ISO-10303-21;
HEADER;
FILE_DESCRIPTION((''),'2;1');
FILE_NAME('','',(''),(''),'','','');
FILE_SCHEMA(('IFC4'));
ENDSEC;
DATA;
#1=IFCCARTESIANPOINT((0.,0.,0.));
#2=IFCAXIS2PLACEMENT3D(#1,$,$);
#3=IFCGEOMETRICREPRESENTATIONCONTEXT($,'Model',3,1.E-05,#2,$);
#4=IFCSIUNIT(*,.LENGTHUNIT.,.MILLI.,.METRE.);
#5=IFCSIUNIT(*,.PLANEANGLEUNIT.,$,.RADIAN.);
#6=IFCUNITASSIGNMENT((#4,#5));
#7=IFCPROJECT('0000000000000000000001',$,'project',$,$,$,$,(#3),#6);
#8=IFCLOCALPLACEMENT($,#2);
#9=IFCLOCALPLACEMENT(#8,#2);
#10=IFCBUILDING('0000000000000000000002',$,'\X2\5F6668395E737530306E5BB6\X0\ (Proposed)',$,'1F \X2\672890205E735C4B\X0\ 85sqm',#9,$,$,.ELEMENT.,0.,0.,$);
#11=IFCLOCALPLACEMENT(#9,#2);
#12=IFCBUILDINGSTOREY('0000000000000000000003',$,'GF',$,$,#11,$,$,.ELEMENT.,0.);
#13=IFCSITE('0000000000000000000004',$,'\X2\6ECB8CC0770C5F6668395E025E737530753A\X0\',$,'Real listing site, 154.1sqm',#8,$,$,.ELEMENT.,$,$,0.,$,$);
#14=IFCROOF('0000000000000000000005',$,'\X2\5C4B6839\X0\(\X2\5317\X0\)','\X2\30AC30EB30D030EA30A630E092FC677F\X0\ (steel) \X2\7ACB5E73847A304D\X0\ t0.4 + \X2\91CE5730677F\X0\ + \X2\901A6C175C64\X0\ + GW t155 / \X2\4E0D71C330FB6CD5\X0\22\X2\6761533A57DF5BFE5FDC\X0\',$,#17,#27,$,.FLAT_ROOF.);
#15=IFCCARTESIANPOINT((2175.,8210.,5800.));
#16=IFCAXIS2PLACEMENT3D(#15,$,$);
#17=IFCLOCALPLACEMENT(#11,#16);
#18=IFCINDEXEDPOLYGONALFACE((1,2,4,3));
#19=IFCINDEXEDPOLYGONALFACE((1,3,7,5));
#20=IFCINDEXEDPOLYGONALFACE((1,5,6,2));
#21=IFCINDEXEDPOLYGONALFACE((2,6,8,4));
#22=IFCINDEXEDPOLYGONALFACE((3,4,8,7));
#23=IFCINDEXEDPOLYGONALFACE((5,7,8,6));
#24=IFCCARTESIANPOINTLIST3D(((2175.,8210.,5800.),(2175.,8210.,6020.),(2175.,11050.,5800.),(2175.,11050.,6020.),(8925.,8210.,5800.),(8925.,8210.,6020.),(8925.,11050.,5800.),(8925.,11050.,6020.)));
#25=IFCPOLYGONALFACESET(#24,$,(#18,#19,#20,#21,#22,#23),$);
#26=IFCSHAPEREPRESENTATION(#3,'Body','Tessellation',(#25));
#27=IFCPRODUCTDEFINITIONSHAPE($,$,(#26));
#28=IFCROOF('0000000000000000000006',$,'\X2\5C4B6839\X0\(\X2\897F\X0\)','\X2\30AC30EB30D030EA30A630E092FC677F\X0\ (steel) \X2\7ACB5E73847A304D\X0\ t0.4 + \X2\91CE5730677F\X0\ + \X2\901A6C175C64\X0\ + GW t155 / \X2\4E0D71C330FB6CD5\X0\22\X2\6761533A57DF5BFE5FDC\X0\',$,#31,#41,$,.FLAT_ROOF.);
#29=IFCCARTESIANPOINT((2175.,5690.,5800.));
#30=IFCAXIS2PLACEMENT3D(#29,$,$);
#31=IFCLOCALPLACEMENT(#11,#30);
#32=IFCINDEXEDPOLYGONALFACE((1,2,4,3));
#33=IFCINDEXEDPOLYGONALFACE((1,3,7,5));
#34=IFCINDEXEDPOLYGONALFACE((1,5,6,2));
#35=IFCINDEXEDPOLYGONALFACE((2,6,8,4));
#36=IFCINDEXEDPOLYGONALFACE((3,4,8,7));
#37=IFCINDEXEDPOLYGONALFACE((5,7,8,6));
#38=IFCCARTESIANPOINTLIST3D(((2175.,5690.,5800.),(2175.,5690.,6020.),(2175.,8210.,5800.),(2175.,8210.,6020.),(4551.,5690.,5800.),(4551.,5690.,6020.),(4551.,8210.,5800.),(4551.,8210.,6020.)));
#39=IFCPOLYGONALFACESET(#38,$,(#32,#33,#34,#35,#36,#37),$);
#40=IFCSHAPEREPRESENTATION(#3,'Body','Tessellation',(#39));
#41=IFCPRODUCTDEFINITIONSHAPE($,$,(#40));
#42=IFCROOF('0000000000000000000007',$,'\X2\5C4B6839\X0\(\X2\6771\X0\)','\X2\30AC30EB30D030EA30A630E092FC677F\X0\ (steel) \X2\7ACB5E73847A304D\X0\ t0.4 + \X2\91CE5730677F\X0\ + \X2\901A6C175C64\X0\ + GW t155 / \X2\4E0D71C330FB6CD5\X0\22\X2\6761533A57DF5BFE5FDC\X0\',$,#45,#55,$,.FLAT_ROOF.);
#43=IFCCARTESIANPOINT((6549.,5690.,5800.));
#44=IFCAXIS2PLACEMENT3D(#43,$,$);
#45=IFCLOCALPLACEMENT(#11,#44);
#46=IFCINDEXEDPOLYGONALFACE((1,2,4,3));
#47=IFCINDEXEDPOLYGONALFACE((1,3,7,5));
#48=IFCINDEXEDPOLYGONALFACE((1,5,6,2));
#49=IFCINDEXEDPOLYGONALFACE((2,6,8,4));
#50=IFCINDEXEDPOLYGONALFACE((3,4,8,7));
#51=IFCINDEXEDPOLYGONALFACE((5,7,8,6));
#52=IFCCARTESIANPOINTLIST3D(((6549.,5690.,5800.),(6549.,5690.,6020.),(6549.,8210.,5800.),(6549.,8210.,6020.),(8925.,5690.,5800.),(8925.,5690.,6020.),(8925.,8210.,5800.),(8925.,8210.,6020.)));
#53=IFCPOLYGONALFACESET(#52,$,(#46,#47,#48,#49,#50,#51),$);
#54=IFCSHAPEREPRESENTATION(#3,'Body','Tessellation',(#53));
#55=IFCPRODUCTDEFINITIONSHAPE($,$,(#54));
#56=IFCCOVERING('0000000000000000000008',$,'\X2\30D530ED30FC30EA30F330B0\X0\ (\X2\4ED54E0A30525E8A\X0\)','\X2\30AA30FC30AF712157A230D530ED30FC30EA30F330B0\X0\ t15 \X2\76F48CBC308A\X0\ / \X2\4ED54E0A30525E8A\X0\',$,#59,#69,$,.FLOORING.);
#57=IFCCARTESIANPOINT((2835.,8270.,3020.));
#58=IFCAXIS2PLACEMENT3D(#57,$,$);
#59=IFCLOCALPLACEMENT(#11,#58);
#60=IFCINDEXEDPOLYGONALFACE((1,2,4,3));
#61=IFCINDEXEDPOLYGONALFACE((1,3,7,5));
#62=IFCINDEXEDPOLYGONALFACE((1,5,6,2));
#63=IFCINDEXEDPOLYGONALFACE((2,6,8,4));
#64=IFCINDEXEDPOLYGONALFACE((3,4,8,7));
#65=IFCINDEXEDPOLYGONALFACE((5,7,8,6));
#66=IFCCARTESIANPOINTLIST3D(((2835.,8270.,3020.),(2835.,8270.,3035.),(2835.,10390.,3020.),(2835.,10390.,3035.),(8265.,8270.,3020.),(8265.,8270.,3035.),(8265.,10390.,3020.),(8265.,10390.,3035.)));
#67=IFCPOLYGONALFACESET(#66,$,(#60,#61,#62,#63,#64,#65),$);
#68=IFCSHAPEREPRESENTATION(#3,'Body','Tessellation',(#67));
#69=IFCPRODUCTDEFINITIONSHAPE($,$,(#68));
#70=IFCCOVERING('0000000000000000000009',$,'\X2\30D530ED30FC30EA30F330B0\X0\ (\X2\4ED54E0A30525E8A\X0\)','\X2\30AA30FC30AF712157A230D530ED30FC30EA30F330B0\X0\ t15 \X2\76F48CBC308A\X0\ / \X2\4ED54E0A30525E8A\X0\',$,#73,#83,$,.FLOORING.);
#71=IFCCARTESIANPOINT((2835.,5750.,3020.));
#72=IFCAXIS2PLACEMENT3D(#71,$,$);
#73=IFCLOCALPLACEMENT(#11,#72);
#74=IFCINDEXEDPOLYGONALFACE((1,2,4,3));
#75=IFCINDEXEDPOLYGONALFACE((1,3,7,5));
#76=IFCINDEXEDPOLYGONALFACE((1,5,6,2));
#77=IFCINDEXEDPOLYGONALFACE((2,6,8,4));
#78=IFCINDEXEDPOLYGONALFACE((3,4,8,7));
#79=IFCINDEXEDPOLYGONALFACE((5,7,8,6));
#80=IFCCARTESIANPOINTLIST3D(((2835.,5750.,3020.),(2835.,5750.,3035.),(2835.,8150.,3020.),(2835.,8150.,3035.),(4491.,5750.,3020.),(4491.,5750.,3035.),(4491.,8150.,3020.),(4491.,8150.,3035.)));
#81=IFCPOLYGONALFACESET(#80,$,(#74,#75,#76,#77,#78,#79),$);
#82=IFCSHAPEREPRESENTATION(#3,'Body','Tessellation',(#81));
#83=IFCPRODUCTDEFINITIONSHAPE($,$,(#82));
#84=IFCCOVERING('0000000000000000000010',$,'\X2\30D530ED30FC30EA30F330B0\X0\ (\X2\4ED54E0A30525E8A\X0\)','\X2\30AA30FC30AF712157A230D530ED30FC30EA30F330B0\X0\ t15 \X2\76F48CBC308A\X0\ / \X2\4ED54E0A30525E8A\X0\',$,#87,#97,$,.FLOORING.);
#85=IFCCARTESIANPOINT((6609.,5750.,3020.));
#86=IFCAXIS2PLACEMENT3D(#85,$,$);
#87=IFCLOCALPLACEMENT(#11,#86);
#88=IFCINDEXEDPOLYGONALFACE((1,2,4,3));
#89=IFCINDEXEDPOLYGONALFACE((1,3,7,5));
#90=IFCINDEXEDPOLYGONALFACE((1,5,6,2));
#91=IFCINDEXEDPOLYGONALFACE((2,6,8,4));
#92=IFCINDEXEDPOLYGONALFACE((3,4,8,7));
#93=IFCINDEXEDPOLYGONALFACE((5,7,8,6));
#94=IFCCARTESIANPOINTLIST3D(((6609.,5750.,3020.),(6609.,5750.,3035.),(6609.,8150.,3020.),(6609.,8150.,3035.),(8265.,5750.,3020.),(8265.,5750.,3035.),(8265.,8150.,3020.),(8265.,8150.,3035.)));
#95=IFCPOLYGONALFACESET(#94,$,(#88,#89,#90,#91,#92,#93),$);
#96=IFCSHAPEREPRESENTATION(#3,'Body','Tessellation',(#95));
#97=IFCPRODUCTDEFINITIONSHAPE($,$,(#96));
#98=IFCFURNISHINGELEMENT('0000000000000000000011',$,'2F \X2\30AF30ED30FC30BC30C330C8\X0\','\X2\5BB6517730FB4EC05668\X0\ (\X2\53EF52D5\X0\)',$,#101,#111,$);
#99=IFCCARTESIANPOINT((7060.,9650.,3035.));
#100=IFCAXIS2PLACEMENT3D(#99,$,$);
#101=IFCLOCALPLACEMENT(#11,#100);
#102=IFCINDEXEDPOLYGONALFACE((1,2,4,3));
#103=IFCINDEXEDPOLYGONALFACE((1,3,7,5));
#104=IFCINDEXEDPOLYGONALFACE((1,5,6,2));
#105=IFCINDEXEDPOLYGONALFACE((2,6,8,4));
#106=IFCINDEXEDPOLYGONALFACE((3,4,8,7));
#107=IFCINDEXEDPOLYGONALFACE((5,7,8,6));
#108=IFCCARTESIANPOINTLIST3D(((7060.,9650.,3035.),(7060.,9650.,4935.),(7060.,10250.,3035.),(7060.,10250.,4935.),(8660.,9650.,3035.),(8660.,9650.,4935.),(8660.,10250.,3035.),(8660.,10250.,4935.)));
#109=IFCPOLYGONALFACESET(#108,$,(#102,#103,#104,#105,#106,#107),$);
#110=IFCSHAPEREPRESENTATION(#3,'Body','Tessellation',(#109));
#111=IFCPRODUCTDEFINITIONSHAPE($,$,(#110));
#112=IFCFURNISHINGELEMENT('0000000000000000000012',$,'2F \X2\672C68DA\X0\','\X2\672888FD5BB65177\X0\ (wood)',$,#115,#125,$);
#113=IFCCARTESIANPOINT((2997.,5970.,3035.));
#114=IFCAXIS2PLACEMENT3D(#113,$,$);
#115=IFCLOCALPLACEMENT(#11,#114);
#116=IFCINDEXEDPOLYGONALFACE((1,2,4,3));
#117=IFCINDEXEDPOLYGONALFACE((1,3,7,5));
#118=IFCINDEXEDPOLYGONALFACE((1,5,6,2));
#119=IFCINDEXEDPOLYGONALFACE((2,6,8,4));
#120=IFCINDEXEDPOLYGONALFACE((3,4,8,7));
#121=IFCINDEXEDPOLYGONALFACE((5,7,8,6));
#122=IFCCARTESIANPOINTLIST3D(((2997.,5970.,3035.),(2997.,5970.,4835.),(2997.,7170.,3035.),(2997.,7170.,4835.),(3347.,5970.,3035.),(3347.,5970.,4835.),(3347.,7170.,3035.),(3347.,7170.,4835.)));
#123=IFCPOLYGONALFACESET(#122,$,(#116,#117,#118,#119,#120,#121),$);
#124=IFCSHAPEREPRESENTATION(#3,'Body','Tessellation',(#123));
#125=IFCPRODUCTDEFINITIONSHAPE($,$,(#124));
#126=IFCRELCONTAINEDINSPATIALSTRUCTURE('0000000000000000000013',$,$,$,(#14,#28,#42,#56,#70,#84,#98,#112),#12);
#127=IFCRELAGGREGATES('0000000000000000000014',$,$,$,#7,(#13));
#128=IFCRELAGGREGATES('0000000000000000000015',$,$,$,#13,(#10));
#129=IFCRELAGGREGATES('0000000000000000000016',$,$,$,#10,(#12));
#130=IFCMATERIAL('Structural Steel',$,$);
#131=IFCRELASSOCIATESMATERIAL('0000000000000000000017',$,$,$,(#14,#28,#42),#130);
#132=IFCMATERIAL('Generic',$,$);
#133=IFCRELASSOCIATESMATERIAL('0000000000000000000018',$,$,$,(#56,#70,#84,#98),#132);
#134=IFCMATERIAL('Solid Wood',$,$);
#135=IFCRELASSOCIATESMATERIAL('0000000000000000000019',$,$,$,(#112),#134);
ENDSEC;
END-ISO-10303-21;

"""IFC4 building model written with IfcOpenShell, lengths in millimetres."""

from ifc_helpers import new_model, si_unit, frame, frame_2d, origin, place, context, project, spatial, rectangle, extrude, material, element, save


model = new_model("IFC4")

# Units and contexts
model_context = context("Model", 3, precision=1e-05, world=origin())
ifc_project = project(units=[si_unit("LENGTHUNIT", "METRE", prefix="MILLI"), si_unit("PLANEANGLEUNIT", "RADIAN")], contexts=[model_context])

# Site, building, storey
site_placement = place(None, origin())
site = spatial("IfcSite", under=ifc_project, at=site_placement, Name="滋賀県彦根市平田町", ObjectType="Real listing site, 154.1sqm", CompositionType="ELEMENT", RefElevation=0.0)
building_placement = place(site_placement, origin())
building = spatial("IfcBuilding", under=site, at=building_placement, Name="彦根平田の家 (Proposed)", ObjectType="1F 木造平屋 85sqm", CompositionType="ELEMENT", ElevationOfRefHeight=0.0, ElevationOfTerrain=0.0)
storey_placement = place(building_placement, origin())
storey = spatial("IfcBuildingStorey", under=building, at=storey_placement, Name="GF", CompositionType="ELEMENT", Elevation=0.0)

# Shared definitions
ifc_material_1 = material(Name="Solid Wood")

# Shared definitions
ifc_material_2 = material(Name="Generic")

# Roofs
ifc_material_3 = material(Name="Structural Steel")
for number, where, name in (
    (1, (2175.0, 8210.0, 5800.0), "屋根(北)"),
):
    element("IfcRoof", number, at=place(storey_placement, frame(where)), inside=storey, material=ifc_material_3, Name=name, Description="ガルバリウム鋼板 (steel) 立平葺き t0.4 + 野地板 + 通気層 + GW t155 / 不燃・法22条区域対応", PredefinedType="FLAT_ROOF", context=model_context, shape_type="SweptSolid", body=[
        extrude(rectangle(XDim=6750.0, YDim=2840.0, at=frame_2d((3375.0, 1420.0))), frame((2175.0, 8210.0, 5800.0)), (0.0, 0.0, 1.0), 220.0),
    ])
roof_1_placement = place(storey_placement, frame((2175.0, 5690.0, 5800.0)))
element("IfcRoof", 2, at=roof_1_placement, inside=storey, material=ifc_material_3, Name="屋根(西)", Description="ガルバリウム鋼板 (steel) 立平葺き t0.4 + 野地板 + 通気層 + GW t155 / 不燃・法22条区域対応", PredefinedType="FLAT_ROOF", context=model_context, shape_type="SweptSolid", body=[
    extrude(rectangle(XDim=2376.0, YDim=2520.0, at=frame_2d((1188.0, 1260.0))), frame((2175.0, 5690.0, 5800.0)), (0.0, 0.0, 1.0), 220.0),
])
roof_2_placement = place(storey_placement, frame((6549.0, 5690.0, 5800.0)))
element("IfcRoof", 3, at=roof_2_placement, inside=storey, material=ifc_material_3, Name="屋根(東)", Description="ガルバリウム鋼板 (steel) 立平葺き t0.4 + 野地板 + 通気層 + GW t155 / 不燃・法22条区域対応", PredefinedType="FLAT_ROOF", context=model_context, shape_type="SweptSolid", body=[
    extrude(rectangle(XDim=2376.0, YDim=2520.0, at=frame_2d((1188.0, 1260.0))), frame((6549.0, 5690.0, 5800.0)), (0.0, 0.0, 1.0), 220.0),
])

# Coverings
covering_1_placement = place(storey_placement, frame((2835.0, 8270.0, 3020.0)))
element("IfcCovering", 4, at=covering_1_placement, inside=storey, material=ifc_material_2, Name="フローリング (仕上げ床)", Description="オーク無垢フローリング t15 直貼り / 仕上げ床", PredefinedType="FLOORING", context=model_context, shape_type="SweptSolid", body=[
    extrude(rectangle(XDim=5430.0, YDim=2120.0, at=frame_2d((2715.0, 1060.0))), frame((2835.0, 8270.0, 3020.0)), (0.0, 0.0, 1.0), 15.0),
])
covering_2_placement = place(storey_placement, frame((2835.0, 5750.0, 3020.0)))
element("IfcCovering", 5, at=covering_2_placement, inside=storey, material=ifc_material_2, Name="フローリング (仕上げ床)", Description="オーク無垢フローリング t15 直貼り / 仕上げ床", PredefinedType="FLOORING", context=model_context, shape_type="SweptSolid", body=[
    extrude(rectangle(XDim=1656.0, YDim=2400.0, at=frame_2d((828.0, 1200.0))), frame((2835.0, 5750.0, 3020.0)), (0.0, 0.0, 1.0), 15.0),
])
covering_3_placement = place(storey_placement, frame((6609.0, 5750.0, 3020.0)))
element("IfcCovering", 6, at=covering_3_placement, inside=storey, material=ifc_material_2, Name="フローリング (仕上げ床)", Description="オーク無垢フローリング t15 直貼り / 仕上げ床", PredefinedType="FLOORING", context=model_context, shape_type="SweptSolid", body=[
    extrude(rectangle(XDim=1656.0, YDim=2400.0, at=frame_2d((828.0, 1200.0))), frame((6609.0, 5750.0, 3020.0)), (0.0, 0.0, 1.0), 15.0),
])

# Furnishing elements
furnishing_1_placement = place(storey_placement, frame((7060.0, 9650.0, 3035.0)))
element("IfcFurnishingElement", 7, at=furnishing_1_placement, inside=storey, material=ifc_material_2, Name="2F クローゼット", Description="家具・什器 (可動)", context=model_context, shape_type="SweptSolid", body=[
    extrude(rectangle(XDim=1600.0, YDim=600.0, at=frame_2d((800.0, 300.0))), frame((7060.0, 9650.0, 3035.0)), (0.0, 0.0, 1.0), 1900.0),
])
furnishing_2_placement = place(storey_placement, frame((2997.0, 5970.0, 3035.0)))
element("IfcFurnishingElement", 8, at=furnishing_2_placement, inside=storey, material=ifc_material_1, Name="2F 本棚", Description="木製家具 (wood)", context=model_context, shape_type="SweptSolid", body=[
    extrude(rectangle(XDim=350.0, YDim=1200.0, at=frame_2d((175.0, 600.0))), frame((2997.0, 5970.0, 3035.0)), (0.0, 0.0, 1.0), 1800.0),
])

save(model, "model.ifc")
